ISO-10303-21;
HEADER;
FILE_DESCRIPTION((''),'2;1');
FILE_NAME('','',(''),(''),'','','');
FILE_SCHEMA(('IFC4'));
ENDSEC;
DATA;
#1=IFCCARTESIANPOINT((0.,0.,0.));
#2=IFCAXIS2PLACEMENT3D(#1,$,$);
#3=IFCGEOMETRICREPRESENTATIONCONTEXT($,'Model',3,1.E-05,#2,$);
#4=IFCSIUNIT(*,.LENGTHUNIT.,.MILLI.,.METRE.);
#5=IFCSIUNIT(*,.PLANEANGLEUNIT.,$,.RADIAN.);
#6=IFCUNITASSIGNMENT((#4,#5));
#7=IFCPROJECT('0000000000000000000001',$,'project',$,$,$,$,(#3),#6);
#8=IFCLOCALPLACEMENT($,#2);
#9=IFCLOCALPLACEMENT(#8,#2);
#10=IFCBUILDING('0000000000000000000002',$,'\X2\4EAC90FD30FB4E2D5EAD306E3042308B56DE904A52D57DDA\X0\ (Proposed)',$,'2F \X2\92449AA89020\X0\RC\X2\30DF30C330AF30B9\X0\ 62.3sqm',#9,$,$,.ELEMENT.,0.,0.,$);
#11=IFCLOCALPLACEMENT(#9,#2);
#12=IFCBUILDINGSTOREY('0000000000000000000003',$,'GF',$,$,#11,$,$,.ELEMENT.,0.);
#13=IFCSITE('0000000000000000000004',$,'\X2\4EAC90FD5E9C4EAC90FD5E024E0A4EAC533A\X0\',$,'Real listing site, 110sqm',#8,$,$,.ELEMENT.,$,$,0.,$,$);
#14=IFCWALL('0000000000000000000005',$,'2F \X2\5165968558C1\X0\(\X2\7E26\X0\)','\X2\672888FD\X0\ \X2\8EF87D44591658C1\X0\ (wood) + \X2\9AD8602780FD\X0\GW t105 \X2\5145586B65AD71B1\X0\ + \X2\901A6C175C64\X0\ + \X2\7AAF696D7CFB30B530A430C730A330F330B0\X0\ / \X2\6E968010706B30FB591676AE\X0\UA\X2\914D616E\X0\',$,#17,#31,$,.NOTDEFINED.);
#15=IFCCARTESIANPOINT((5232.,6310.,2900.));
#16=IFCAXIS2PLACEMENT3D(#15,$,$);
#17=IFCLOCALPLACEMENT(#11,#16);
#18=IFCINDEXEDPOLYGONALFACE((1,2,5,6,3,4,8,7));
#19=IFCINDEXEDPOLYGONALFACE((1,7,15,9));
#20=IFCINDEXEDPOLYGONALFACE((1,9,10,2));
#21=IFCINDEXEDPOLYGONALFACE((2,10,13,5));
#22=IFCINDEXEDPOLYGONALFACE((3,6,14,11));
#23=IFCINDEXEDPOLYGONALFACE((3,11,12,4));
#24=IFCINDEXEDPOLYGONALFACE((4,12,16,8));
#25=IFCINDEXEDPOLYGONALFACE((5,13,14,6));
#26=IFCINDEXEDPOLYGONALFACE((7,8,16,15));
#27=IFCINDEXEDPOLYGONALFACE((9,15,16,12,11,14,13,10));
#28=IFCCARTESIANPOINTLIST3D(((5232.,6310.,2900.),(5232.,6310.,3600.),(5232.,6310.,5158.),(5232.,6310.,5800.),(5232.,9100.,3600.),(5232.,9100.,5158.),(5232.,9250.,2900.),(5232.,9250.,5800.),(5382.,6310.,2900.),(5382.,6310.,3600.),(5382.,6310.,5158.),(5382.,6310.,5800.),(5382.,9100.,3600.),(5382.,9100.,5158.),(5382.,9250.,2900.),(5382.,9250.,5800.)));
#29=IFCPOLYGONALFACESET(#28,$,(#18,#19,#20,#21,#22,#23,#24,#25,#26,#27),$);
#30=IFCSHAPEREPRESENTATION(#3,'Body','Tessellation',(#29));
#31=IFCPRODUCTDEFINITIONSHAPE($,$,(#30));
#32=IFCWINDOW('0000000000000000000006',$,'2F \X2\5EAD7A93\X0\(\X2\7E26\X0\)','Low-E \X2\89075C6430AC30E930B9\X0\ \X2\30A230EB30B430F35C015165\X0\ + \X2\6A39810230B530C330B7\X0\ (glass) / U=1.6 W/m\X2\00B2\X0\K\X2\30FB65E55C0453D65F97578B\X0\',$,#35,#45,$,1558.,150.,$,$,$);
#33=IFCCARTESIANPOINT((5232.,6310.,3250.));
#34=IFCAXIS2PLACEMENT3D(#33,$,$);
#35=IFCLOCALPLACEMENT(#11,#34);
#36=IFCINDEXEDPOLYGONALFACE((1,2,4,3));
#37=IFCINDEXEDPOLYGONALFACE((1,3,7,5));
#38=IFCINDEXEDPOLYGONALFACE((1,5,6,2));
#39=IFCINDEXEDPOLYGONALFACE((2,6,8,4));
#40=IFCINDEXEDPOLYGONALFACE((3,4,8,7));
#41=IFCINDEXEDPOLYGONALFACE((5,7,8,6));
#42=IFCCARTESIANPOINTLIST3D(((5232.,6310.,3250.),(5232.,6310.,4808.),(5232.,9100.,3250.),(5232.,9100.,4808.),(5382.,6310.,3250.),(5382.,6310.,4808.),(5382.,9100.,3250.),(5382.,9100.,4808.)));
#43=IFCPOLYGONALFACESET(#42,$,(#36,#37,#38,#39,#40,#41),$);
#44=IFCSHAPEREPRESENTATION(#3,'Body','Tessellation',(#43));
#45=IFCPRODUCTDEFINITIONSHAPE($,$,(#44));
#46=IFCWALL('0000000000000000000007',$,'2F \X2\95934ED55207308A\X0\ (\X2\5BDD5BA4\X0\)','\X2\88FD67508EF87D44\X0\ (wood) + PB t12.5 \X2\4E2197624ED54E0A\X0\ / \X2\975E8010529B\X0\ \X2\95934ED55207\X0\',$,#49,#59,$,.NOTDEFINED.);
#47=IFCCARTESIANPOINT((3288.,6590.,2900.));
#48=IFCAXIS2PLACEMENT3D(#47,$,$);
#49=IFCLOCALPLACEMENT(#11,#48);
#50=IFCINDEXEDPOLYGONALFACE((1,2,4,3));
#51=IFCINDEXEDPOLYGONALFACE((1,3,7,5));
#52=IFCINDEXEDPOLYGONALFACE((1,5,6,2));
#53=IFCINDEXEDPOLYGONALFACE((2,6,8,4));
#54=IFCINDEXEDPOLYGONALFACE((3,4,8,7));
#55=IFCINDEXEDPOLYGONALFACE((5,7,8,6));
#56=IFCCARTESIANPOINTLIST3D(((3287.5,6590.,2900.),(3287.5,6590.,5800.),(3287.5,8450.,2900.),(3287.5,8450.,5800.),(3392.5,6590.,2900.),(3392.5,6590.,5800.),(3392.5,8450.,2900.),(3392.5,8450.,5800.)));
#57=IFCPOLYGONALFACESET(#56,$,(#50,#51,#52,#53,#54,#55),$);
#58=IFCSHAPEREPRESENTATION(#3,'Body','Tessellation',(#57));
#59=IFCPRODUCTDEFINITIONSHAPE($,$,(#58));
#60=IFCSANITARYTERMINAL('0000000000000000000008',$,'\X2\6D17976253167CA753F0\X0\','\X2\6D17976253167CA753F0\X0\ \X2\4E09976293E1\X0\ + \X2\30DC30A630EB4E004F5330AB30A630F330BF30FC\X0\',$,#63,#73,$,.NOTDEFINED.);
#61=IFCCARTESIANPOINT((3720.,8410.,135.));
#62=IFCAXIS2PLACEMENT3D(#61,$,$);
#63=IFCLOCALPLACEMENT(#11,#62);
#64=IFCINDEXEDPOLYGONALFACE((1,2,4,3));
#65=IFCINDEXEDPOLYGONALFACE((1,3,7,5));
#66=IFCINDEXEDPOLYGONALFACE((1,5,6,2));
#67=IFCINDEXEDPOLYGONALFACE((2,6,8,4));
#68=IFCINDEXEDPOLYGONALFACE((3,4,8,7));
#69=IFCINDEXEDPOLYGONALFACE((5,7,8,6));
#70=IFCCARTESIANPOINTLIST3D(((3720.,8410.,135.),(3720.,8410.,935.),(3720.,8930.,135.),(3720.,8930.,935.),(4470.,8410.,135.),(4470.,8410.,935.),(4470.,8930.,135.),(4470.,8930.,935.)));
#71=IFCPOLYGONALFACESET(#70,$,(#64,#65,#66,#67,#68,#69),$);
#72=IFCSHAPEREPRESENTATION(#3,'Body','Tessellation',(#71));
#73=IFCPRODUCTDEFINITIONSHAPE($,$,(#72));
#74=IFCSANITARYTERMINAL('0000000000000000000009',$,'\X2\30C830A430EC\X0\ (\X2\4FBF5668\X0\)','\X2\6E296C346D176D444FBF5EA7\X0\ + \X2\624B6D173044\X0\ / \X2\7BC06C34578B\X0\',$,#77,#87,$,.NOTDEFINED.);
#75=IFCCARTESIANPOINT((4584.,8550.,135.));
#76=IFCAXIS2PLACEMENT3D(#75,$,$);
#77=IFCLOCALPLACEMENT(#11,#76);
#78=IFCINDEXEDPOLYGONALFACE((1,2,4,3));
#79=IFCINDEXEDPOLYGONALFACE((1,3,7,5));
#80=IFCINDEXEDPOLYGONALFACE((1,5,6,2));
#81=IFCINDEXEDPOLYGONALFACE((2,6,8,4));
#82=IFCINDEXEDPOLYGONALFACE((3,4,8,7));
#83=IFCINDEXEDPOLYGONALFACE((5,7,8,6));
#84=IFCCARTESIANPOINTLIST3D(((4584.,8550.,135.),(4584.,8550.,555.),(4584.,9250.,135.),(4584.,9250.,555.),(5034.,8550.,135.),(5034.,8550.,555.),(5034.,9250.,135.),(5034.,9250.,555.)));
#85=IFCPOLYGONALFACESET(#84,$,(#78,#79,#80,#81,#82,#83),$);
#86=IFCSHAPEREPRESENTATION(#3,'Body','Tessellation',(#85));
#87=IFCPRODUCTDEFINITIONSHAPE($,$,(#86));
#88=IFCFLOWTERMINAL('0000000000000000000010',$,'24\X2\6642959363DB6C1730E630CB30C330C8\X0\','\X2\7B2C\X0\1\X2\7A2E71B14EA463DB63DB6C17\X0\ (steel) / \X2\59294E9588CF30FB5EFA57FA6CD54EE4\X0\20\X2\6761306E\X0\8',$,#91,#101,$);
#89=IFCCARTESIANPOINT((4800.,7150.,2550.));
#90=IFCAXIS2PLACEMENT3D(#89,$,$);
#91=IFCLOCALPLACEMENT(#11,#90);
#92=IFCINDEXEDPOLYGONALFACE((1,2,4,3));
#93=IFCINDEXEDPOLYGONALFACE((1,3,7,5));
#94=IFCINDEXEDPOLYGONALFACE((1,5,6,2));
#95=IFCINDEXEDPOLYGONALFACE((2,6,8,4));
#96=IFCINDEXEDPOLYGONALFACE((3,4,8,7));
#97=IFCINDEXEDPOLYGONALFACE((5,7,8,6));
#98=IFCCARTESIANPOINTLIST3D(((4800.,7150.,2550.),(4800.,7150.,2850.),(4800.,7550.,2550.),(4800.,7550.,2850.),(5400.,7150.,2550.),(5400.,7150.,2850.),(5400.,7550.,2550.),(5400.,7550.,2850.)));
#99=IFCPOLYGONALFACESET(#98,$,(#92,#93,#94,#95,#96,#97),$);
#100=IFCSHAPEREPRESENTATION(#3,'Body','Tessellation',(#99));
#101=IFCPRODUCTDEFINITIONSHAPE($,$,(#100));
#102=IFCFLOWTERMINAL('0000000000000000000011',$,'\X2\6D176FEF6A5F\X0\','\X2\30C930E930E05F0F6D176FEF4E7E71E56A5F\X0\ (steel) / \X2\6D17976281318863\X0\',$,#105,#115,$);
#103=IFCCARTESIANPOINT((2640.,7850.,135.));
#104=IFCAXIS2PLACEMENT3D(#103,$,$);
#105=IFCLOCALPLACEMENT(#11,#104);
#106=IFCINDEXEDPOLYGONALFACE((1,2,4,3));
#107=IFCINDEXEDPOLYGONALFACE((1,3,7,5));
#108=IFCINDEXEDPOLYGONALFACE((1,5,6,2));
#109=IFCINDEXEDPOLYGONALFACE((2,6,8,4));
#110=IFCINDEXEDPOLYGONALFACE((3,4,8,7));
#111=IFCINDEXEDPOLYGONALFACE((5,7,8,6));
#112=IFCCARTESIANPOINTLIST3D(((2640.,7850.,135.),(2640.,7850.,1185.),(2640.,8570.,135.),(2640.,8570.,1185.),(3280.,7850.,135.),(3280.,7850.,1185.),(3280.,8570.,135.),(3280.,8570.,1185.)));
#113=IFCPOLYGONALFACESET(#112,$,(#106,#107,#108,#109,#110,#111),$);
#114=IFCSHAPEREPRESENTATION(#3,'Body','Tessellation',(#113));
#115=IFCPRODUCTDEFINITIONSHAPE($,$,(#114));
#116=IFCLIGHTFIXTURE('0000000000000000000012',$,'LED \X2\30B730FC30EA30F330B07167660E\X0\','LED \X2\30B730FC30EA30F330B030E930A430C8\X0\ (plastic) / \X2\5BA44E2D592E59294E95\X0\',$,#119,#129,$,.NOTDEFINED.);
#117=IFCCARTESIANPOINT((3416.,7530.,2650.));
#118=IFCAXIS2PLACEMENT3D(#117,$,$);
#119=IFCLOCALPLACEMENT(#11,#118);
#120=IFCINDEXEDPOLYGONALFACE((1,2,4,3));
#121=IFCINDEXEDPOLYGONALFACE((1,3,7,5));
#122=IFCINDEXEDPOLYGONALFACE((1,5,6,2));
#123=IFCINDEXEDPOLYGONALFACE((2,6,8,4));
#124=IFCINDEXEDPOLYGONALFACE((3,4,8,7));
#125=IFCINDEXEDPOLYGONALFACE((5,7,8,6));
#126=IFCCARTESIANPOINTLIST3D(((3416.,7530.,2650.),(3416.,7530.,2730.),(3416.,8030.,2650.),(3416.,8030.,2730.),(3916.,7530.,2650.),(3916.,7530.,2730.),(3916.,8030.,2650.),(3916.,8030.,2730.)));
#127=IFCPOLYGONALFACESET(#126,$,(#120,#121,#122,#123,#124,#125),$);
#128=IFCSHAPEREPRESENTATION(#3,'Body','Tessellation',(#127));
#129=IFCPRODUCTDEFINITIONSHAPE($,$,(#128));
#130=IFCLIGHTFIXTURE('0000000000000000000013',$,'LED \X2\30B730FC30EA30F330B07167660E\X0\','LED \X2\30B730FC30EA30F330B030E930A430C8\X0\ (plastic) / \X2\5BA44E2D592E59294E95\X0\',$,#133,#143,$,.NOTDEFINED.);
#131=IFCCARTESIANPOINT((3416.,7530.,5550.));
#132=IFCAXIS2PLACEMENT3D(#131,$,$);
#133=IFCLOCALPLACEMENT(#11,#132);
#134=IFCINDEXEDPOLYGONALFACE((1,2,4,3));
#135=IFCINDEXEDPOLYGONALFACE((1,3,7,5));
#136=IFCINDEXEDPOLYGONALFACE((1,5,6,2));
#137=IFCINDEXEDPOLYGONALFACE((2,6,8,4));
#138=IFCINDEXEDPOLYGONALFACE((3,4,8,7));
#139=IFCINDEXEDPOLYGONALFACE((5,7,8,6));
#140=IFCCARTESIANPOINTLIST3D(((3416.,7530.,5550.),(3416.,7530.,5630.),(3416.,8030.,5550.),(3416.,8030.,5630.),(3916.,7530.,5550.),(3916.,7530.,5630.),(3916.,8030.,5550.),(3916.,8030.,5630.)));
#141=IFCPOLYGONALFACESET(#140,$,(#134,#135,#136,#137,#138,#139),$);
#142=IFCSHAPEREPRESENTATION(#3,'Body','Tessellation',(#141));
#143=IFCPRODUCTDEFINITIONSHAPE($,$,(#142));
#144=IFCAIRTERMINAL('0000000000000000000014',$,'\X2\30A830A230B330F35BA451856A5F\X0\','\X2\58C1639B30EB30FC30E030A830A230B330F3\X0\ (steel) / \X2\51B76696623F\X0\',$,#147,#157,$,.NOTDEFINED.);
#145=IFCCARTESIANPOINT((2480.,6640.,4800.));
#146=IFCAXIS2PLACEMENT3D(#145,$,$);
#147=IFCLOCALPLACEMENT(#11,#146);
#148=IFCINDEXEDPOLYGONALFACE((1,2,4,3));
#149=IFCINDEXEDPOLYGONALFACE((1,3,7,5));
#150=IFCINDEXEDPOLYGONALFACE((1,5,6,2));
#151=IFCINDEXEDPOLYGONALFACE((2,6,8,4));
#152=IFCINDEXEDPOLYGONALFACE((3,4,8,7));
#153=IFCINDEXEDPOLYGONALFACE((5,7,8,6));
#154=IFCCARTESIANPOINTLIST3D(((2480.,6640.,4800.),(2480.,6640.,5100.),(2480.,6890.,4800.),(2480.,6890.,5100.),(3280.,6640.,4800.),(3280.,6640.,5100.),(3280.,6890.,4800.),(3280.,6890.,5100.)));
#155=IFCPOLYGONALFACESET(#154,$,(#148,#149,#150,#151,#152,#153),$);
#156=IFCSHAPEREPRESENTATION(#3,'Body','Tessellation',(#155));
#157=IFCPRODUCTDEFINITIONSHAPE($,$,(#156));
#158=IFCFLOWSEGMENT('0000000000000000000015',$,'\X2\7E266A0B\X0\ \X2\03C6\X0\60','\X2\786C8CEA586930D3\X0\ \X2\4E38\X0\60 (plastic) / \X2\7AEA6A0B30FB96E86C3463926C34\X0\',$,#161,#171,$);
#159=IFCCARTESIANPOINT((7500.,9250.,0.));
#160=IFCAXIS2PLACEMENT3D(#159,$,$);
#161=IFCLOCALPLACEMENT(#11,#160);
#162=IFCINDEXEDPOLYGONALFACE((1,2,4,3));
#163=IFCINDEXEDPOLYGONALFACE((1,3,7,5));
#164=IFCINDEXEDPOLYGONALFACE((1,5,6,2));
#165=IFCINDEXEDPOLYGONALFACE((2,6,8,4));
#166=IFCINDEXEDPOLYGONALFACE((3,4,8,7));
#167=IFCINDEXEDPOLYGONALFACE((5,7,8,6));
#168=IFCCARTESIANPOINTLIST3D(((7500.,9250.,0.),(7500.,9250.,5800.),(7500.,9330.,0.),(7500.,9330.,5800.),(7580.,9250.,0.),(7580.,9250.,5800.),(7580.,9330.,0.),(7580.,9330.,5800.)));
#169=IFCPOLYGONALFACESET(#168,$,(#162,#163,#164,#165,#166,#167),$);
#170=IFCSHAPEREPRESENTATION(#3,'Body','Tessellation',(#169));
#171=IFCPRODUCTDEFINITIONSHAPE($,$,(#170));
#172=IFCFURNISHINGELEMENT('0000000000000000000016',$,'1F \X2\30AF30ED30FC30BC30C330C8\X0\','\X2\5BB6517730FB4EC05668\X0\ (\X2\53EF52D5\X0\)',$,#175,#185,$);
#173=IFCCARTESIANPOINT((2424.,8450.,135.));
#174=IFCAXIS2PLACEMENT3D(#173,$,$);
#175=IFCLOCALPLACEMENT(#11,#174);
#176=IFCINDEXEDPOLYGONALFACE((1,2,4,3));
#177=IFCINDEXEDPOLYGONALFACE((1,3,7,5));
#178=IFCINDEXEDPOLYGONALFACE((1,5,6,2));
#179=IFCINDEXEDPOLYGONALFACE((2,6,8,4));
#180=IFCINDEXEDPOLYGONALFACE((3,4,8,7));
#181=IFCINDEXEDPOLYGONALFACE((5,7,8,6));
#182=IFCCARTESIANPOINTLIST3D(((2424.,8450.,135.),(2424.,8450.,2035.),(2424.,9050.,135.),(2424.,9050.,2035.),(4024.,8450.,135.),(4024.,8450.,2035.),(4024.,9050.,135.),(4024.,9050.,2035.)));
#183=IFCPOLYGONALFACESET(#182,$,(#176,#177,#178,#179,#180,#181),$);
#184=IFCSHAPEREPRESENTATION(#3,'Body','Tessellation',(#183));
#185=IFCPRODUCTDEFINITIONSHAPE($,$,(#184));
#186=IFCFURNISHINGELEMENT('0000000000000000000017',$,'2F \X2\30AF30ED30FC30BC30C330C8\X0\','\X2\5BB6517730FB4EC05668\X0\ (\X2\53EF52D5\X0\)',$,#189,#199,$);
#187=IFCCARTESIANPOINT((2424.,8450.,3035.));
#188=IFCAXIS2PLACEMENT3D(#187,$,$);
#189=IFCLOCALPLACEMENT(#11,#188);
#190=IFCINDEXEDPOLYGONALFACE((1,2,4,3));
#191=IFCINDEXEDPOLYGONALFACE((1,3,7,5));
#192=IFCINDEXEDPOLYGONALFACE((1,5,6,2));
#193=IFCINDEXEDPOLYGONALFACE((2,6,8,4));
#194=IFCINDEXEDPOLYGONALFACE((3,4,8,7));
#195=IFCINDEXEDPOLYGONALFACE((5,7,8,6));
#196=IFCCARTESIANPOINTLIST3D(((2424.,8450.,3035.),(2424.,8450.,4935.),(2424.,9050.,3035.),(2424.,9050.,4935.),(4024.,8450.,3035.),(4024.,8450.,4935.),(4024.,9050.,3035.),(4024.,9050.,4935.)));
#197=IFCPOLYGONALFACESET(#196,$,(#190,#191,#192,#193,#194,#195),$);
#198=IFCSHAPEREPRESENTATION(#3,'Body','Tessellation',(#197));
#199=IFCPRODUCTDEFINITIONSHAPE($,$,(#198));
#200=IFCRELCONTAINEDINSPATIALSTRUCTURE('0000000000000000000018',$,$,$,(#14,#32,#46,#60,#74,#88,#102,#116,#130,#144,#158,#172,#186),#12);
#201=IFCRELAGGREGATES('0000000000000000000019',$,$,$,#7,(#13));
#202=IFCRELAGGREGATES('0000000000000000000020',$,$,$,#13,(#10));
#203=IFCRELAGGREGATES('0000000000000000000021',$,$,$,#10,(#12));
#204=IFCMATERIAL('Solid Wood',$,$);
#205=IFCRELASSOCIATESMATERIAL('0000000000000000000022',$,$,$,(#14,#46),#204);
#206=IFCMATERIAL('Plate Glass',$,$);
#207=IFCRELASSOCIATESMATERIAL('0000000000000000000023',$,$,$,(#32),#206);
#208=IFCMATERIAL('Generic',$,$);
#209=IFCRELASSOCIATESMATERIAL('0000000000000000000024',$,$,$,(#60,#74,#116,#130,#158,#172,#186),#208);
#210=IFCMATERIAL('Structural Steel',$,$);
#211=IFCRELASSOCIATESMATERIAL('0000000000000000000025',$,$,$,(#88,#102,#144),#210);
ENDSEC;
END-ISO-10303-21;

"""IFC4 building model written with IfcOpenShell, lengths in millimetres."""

from ifc_helpers import new_model, si_unit, frame, frame_2d, origin, place, context, project, spatial, rectangle, extrude, material, element, fill, save


model = new_model("IFC4")

# Units and contexts
model_context = context("Model", 3, precision=1e-05, world=origin())
ifc_project = project(units=[si_unit("LENGTHUNIT", "METRE", prefix="MILLI"), si_unit("PLANEANGLEUNIT", "RADIAN")], contexts=[model_context])

# Site, building, storey
site_placement = place(None, origin())
site = spatial("IfcSite", under=ifc_project, at=site_placement, Name="京都府京都市上京区", ObjectType="Real listing site, 110sqm", CompositionType="ELEMENT", RefElevation=0.0)
building_placement = place(site_placement, origin())
building = spatial("IfcBuilding", under=site, at=building_placement, Name="京都・中庭のある回遊動線 (Proposed)", ObjectType="2F 鉄骨造RCミックス 62.3sqm", CompositionType="ELEMENT", ElevationOfRefHeight=0.0, ElevationOfTerrain=0.0)
storey_placement = place(building_placement, origin())
storey = spatial("IfcBuildingStorey", under=building, at=storey_placement, Name="GF", CompositionType="ELEMENT", Elevation=0.0)

# Shared definitions
ifc_material_1 = material(Name="Solid Wood")

# Shared definitions
ifc_material_2 = material(Name="Plate Glass")

# Wall, opening, window
wall_1_placement = place(storey_placement, frame((5232.0, 6310.0, 2900.0)))
wall_1 = element("IfcWall", 1, at=wall_1_placement, inside=storey, material=ifc_material_1, Name="2F 入隅壁(縦)", Description="木製 軸組外壁 (wood) + 高性能GW t105 充填断熱 + 通気層 + 窯業系サイディング / 準耐火・外皮UA配慮", PredefinedType="NOTDEFINED", context=model_context, shape_type="SweptSolid", body=[
    extrude(rectangle(XDim=150.0, YDim=2940.0, at=frame_2d((75.0, 1470.0))), frame((5232.0, 6310.0, 2900.0)), (0.0, 0.0, 1.0), 2900.0),
])
opening_1_placement = place(storey_placement, frame((5232.0, 6310.0, 3250.0)))
opening_1 = element("IfcOpeningElement", 2, at=opening_1_placement, cuts=wall_1, PredefinedType="NOTDEFINED", context=model_context, shape_type="SweptSolid", body=[
    extrude(rectangle(XDim=150.0, YDim=2790.0, at=frame_2d((75.0, 1395.0))), frame((5232.0, 6310.0, 3250.0)), (0.0, 0.0, 1.0), 1558.0),
])
window_1_placement = place(storey_placement, frame((5232.0, 6310.0, 3250.0)))
window_1 = element("IfcWindow", 3, at=window_1_placement, inside=storey, material=ifc_material_2, Name="2F 庭窓(縦)", Description="Low-E 複層ガラス アルゴン封入 + 樹脂サッシ (glass) / U=1.6 W/m²K・日射取得型", OverallHeight=1558.0, OverallWidth=150.0, context=model_context, shape_type="SweptSolid", body=[
    extrude(rectangle(XDim=150.0, YDim=2790.0, at=frame_2d((75.0, 1395.0))), frame((5232.0, 6310.0, 3250.0)), (0.0, 0.0, 1.0), 1558.0),
])
fill(opening_1, window_1)

# Wall
wall_2_placement = place(storey_placement, frame((3288.0, 6590.0, 2900.0)))
element("IfcWall", 4, at=wall_2_placement, inside=storey, material=ifc_material_1, Name="2F 間仕切り (寝室)", Description="製材軸組 (wood) + PB t12.5 両面仕上 / 非耐力 間仕切", PredefinedType="NOTDEFINED", context=model_context, shape_type="SweptSolid", body=[
    extrude(rectangle(XDim=105.0, YDim=1860.0, at=frame_2d((52.0, 930.0))), frame((3288.0, 6590.0, 2900.0)), (0.0, 0.0, 1.0), 2900.0),
])

# Sanitary terminals
ifc_material_3 = material(Name="Generic")
sanitary_terminal_1_placement = place(storey_placement, frame((3720.0, 8410.0, 135.0)))
element("IfcSanitaryTerminal", 5, at=sanitary_terminal_1_placement, inside=storey, material=ifc_material_3, Name="洗面化粧台", Description="洗面化粧台 三面鏡 + ボウル一体カウンター", PredefinedType="NOTDEFINED", context=model_context, shape_type="SweptSolid", body=[
    extrude(rectangle(XDim=750.0, YDim=520.0, at=frame_2d((375.0, 260.0))), frame((3720.0, 8410.0, 135.0)), (0.0, 0.0, 1.0), 800.0),
])
sanitary_terminal_2_placement = place(storey_placement, frame((4584.0, 8550.0, 135.0)))
element("IfcSanitaryTerminal", 6, at=sanitary_terminal_2_placement, inside=storey, material=ifc_material_3, Name="トイレ (便器)", Description="温水洗浄便座 + 手洗い / 節水型", PredefinedType="NOTDEFINED", context=model_context, shape_type="SweptSolid", body=[
    extrude(rectangle(XDim=450.0, YDim=700.0, at=frame_2d((225.0, 350.0))), frame((4584.0, 8550.0, 135.0)), (0.0, 0.0, 1.0), 420.0),
])

# Flow terminals
ifc_material_4 = material(Name="Structural Steel")
flow_terminal_1_placement = place(storey_placement, frame((4800.0, 7150.0, 2550.0)))
element("IfcFlowTerminal", 7, at=flow_terminal_1_placement, inside=storey, material=ifc_material_4, Name="24時間換気ユニット", Description="第1種熱交換換気 (steel) / 天井裏・建基法令20条の8", context=model_context, shape_type="SweptSolid", body=[
    extrude(rectangle(XDim=600.0, YDim=400.0, at=frame_2d((300.0, 200.0))), frame((4800.0, 7150.0, 2550.0)), (0.0, 0.0, 1.0), 300.0),
])
flow_terminal_2_placement = place(storey_placement, frame((2640.0, 7850.0, 135.0)))
element("IfcFlowTerminal", 8, at=flow_terminal_2_placement, inside=storey, material=ifc_material_4, Name="洗濯機", Description="ドラム式洗濯乾燥機 (steel) / 洗面脱衣", context=model_context, shape_type="SweptSolid", body=[
    extrude(rectangle(XDim=640.0, YDim=720.0, at=frame_2d((320.0, 360.0))), frame((2640.0, 7850.0, 135.0)), (0.0, 0.0, 1.0), 1050.0),
])

# Light fixtures
light_fixture_1_placement = place(storey_placement, frame((3416.0, 7530.0, 2650.0)))
element("IfcLightFixture", 9, at=light_fixture_1_placement, inside=storey, material=ifc_material_3, Name="LED シーリング照明", Description="LED シーリングライト (plastic) / 室中央天井", PredefinedType="NOTDEFINED", context=model_context, shape_type="SweptSolid", body=[
    extrude(rectangle(XDim=500.0, YDim=500.0, at=frame_2d((250.0, 250.0))), frame((3416.0, 7530.0, 2650.0)), (0.0, 0.0, 1.0), 80.0),
])
light_fixture_2_placement = place(storey_placement, frame((3416.0, 7530.0, 5550.0)))
element("IfcLightFixture", 10, at=light_fixture_2_placement, inside=storey, material=ifc_material_3, Name="LED シーリング照明", Description="LED シーリングライト (plastic) / 室中央天井", PredefinedType="NOTDEFINED", context=model_context, shape_type="SweptSolid", body=[
    extrude(rectangle(XDim=500.0, YDim=500.0, at=frame_2d((250.0, 250.0))), frame((3416.0, 7530.0, 5550.0)), (0.0, 0.0, 1.0), 80.0),
])

# Air terminal
air_terminal_placement = place(storey_placement, frame((2480.0, 6640.0, 4800.0)))
element("IfcAirTerminal", 11, at=air_terminal_placement, inside=storey, material=ifc_material_4, Name="エアコン室内機", Description="壁掛ルームエアコン (steel) / 冷暖房", PredefinedType="NOTDEFINED", context=model_context, shape_type="SweptSolid", body=[
    extrude(rectangle(XDim=800.0, YDim=250.0, at=frame_2d((400.0, 125.0))), frame((2480.0, 6640.0, 4800.0)), (0.0, 0.0, 1.0), 300.0),
])

# Flow segment
flow_segment_placement = place(storey_placement, frame((7500.0, 9250.0, 0.0)))
element("IfcFlowSegment", 12, at=flow_segment_placement, inside=storey, material=ifc_material_3, Name="縦樋 φ60", Description="硬質塩ビ 丸60 (plastic) / 竪樋・雨水排水", context=model_context, shape_type="SweptSolid", body=[
    extrude(rectangle(XDim=80.0, YDim=80.0, at=frame_2d((40.0, 40.0))), frame((7500.0, 9250.0, 0.0)), (0.0, 0.0, 1.0), 5800.0),
])

# Furnishing elements
furnishing_1_placement = place(storey_placement, frame((2424.0, 8450.0, 135.0)))
element("IfcFurnishingElement", 13, at=furnishing_1_placement, inside=storey, material=ifc_material_3, Name="1F クローゼット", Description="家具・什器 (可動)", context=model_context, shape_type="SweptSolid", body=[
    extrude(rectangle(XDim=1600.0, YDim=600.0, at=frame_2d((800.0, 300.0))), frame((2424.0, 8450.0, 135.0)), (0.0, 0.0, 1.0), 1900.0),
])
furnishing_2_placement = place(storey_placement, frame((2424.0, 8450.0, 3035.0)))
element("IfcFurnishingElement", 14, at=furnishing_2_placement, inside=storey, material=ifc_material_3, Name="2F クローゼット", Description="家具・什器 (可動)", context=model_context, shape_type="SweptSolid", body=[
    extrude(rectangle(XDim=1600.0, YDim=600.0, at=frame_2d((800.0, 300.0))), frame((2424.0, 8450.0, 3035.0)), (0.0, 0.0, 1.0), 1900.0),
])

save(model, "model.ifc")
